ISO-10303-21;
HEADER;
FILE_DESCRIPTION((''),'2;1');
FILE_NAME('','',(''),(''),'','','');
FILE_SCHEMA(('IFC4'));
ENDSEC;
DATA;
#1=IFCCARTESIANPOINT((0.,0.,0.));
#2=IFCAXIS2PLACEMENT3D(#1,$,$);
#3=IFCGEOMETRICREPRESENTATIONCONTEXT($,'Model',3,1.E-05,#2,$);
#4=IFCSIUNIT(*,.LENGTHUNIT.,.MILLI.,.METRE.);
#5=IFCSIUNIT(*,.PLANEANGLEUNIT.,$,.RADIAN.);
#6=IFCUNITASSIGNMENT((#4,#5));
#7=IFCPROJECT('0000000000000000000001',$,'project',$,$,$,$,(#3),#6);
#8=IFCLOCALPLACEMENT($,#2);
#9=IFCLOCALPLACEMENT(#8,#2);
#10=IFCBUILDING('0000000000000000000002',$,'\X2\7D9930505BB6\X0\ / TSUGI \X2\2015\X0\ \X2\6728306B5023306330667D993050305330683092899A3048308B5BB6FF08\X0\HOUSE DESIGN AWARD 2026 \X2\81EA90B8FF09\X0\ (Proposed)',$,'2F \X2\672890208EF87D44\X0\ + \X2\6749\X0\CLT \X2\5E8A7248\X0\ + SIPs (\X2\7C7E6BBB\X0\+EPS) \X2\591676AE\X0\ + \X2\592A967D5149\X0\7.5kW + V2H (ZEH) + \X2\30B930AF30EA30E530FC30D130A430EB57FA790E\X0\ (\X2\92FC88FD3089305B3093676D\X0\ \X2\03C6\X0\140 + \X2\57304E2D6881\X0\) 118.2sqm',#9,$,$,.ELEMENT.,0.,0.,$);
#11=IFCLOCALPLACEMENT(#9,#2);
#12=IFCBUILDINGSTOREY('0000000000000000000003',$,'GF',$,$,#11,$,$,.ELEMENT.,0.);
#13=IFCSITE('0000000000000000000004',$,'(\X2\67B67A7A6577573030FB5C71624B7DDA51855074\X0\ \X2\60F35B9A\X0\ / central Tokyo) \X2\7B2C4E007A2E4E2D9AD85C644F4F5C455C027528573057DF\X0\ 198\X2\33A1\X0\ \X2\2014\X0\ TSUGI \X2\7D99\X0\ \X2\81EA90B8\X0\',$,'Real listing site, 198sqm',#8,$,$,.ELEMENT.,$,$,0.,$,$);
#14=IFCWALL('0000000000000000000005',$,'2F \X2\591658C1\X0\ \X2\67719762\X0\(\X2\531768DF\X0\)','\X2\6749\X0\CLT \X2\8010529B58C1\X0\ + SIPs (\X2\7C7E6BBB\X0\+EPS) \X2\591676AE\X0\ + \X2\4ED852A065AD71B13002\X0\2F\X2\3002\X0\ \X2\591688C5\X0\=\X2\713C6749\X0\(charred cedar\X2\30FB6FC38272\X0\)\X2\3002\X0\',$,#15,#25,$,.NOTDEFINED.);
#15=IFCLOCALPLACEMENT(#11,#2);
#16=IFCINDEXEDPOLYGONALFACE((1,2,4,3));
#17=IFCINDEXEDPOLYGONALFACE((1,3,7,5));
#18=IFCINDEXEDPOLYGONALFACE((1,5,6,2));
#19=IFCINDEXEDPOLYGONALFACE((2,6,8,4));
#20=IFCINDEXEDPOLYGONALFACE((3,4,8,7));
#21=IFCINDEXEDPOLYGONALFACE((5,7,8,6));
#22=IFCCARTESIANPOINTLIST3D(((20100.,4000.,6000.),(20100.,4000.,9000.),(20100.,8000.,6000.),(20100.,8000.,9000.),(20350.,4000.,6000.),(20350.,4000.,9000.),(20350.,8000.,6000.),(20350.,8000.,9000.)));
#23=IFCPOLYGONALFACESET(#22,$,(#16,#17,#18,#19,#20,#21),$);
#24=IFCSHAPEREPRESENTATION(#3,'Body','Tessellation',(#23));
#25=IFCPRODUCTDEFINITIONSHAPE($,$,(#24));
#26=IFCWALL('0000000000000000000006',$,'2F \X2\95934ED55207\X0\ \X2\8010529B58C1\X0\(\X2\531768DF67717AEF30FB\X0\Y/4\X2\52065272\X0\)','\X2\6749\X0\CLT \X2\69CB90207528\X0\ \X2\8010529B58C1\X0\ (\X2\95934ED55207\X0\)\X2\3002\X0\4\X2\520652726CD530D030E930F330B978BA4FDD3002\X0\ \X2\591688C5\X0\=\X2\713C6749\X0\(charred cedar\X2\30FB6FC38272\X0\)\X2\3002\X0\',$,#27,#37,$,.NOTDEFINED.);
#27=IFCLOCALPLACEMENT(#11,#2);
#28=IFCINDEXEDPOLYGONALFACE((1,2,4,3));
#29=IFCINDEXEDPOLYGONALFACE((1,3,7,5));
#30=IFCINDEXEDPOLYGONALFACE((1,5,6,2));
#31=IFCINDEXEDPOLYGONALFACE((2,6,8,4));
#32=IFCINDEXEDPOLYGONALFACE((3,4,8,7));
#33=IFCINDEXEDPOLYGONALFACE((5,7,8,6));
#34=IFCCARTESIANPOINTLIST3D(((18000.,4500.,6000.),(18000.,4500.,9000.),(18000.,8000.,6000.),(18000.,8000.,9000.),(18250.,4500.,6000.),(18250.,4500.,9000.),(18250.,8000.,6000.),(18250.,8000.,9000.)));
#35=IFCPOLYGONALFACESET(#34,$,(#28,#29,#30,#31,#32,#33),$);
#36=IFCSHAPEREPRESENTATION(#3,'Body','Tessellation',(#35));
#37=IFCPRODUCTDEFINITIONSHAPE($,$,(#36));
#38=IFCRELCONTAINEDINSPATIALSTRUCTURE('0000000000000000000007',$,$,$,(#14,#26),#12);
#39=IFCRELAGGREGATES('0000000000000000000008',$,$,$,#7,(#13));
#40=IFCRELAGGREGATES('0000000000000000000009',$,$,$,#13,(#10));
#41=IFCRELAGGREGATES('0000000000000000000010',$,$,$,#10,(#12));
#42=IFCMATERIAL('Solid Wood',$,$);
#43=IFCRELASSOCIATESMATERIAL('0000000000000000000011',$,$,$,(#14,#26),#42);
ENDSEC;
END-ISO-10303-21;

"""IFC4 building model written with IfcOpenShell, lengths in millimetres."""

from ifc_helpers import new_model, si_unit, frame, frame_2d, origin, place, context, project, spatial, rectangle, extrude, material, element, save


model = new_model("IFC4")

# Units and contexts
model_context = context("Model", 3, precision=1e-05, world=origin())
ifc_project = project(units=[si_unit("LENGTHUNIT", "METRE", prefix="MILLI"), si_unit("PLANEANGLEUNIT", "RADIAN")], contexts=[model_context])

# Site, building, storey
site_placement = place(None, origin())
site = spatial("IfcSite", under=ifc_project, at=site_placement, Name="(架空敷地・山手線内側 想定 / central Tokyo) 第一種中高層住居専用地域 198㎡ — TSUGI 継 自邸", ObjectType="Real listing site, 198sqm", CompositionType="ELEMENT", RefElevation=0.0)
building_placement = place(site_placement, origin())
building = spatial("IfcBuilding", under=site, at=building_placement, Name="継ぐ家 / TSUGI ― 木に倣って継ぐことを覚える家（HOUSE DESIGN AWARD 2026 自邸） (Proposed)", ObjectType="2F 木造軸組 + 杉CLT 床版 + SIPs (籾殻+EPS) 外皮 + 太陽光7.5kW + V2H (ZEH) + スクリューパイル基礎 (鋼製らせん杭 φ140 + 地中梁) 118.2sqm", CompositionType="ELEMENT", ElevationOfRefHeight=0.0, ElevationOfTerrain=0.0)
storey_placement = place(building_placement, origin())
storey = spatial("IfcBuildingStorey", under=building, at=storey_placement, Name="GF", CompositionType="ELEMENT", Elevation=0.0)

# Walls
ifc_material_1 = material(Name="Solid Wood")
wall_1_placement = place(storey_placement, frame((10050.0, 2000.0, 3000.0)))
element("IfcWall", 1, at=wall_1_placement, inside=storey, material=ifc_material_1, Name="2F 外壁 東面(北棟)", Description="杉CLT 耐力壁 + SIPs (籾殻+EPS) 外皮 + 付加断熱。2F。 外装=焼杉(charred cedar・濃色)。", PredefinedType="NOTDEFINED", context=model_context, shape_type="SweptSolid", body=[
    extrude(rectangle(XDim=250.0, YDim=4000.0, at=frame_2d((125.0, 2000.0))), frame((10050.0, 2000.0, 3000.0)), (0.0, 0.0, 1.0), 3000.0),
])
wall_2_placement = place(storey_placement, frame((9000.0, 2250.0, 3000.0)))
element("IfcWall", 2, at=wall_2_placement, inside=storey, material=ifc_material_1, Name="2F 間仕切 耐力壁(北棟東端・Y/4分割)", Description="杉CLT 構造用 耐力壁 (間仕切)。4分割法バランス確保。 外装=焼杉(charred cedar・濃色)。", PredefinedType="NOTDEFINED", context=model_context, shape_type="SweptSolid", body=[
    extrude(rectangle(XDim=250.0, YDim=3500.0, at=frame_2d((125.0, 1750.0))), frame((9000.0, 2250.0, 3000.0)), (0.0, 0.0, 1.0), 3000.0),
])

save(model, "model.ifc")
